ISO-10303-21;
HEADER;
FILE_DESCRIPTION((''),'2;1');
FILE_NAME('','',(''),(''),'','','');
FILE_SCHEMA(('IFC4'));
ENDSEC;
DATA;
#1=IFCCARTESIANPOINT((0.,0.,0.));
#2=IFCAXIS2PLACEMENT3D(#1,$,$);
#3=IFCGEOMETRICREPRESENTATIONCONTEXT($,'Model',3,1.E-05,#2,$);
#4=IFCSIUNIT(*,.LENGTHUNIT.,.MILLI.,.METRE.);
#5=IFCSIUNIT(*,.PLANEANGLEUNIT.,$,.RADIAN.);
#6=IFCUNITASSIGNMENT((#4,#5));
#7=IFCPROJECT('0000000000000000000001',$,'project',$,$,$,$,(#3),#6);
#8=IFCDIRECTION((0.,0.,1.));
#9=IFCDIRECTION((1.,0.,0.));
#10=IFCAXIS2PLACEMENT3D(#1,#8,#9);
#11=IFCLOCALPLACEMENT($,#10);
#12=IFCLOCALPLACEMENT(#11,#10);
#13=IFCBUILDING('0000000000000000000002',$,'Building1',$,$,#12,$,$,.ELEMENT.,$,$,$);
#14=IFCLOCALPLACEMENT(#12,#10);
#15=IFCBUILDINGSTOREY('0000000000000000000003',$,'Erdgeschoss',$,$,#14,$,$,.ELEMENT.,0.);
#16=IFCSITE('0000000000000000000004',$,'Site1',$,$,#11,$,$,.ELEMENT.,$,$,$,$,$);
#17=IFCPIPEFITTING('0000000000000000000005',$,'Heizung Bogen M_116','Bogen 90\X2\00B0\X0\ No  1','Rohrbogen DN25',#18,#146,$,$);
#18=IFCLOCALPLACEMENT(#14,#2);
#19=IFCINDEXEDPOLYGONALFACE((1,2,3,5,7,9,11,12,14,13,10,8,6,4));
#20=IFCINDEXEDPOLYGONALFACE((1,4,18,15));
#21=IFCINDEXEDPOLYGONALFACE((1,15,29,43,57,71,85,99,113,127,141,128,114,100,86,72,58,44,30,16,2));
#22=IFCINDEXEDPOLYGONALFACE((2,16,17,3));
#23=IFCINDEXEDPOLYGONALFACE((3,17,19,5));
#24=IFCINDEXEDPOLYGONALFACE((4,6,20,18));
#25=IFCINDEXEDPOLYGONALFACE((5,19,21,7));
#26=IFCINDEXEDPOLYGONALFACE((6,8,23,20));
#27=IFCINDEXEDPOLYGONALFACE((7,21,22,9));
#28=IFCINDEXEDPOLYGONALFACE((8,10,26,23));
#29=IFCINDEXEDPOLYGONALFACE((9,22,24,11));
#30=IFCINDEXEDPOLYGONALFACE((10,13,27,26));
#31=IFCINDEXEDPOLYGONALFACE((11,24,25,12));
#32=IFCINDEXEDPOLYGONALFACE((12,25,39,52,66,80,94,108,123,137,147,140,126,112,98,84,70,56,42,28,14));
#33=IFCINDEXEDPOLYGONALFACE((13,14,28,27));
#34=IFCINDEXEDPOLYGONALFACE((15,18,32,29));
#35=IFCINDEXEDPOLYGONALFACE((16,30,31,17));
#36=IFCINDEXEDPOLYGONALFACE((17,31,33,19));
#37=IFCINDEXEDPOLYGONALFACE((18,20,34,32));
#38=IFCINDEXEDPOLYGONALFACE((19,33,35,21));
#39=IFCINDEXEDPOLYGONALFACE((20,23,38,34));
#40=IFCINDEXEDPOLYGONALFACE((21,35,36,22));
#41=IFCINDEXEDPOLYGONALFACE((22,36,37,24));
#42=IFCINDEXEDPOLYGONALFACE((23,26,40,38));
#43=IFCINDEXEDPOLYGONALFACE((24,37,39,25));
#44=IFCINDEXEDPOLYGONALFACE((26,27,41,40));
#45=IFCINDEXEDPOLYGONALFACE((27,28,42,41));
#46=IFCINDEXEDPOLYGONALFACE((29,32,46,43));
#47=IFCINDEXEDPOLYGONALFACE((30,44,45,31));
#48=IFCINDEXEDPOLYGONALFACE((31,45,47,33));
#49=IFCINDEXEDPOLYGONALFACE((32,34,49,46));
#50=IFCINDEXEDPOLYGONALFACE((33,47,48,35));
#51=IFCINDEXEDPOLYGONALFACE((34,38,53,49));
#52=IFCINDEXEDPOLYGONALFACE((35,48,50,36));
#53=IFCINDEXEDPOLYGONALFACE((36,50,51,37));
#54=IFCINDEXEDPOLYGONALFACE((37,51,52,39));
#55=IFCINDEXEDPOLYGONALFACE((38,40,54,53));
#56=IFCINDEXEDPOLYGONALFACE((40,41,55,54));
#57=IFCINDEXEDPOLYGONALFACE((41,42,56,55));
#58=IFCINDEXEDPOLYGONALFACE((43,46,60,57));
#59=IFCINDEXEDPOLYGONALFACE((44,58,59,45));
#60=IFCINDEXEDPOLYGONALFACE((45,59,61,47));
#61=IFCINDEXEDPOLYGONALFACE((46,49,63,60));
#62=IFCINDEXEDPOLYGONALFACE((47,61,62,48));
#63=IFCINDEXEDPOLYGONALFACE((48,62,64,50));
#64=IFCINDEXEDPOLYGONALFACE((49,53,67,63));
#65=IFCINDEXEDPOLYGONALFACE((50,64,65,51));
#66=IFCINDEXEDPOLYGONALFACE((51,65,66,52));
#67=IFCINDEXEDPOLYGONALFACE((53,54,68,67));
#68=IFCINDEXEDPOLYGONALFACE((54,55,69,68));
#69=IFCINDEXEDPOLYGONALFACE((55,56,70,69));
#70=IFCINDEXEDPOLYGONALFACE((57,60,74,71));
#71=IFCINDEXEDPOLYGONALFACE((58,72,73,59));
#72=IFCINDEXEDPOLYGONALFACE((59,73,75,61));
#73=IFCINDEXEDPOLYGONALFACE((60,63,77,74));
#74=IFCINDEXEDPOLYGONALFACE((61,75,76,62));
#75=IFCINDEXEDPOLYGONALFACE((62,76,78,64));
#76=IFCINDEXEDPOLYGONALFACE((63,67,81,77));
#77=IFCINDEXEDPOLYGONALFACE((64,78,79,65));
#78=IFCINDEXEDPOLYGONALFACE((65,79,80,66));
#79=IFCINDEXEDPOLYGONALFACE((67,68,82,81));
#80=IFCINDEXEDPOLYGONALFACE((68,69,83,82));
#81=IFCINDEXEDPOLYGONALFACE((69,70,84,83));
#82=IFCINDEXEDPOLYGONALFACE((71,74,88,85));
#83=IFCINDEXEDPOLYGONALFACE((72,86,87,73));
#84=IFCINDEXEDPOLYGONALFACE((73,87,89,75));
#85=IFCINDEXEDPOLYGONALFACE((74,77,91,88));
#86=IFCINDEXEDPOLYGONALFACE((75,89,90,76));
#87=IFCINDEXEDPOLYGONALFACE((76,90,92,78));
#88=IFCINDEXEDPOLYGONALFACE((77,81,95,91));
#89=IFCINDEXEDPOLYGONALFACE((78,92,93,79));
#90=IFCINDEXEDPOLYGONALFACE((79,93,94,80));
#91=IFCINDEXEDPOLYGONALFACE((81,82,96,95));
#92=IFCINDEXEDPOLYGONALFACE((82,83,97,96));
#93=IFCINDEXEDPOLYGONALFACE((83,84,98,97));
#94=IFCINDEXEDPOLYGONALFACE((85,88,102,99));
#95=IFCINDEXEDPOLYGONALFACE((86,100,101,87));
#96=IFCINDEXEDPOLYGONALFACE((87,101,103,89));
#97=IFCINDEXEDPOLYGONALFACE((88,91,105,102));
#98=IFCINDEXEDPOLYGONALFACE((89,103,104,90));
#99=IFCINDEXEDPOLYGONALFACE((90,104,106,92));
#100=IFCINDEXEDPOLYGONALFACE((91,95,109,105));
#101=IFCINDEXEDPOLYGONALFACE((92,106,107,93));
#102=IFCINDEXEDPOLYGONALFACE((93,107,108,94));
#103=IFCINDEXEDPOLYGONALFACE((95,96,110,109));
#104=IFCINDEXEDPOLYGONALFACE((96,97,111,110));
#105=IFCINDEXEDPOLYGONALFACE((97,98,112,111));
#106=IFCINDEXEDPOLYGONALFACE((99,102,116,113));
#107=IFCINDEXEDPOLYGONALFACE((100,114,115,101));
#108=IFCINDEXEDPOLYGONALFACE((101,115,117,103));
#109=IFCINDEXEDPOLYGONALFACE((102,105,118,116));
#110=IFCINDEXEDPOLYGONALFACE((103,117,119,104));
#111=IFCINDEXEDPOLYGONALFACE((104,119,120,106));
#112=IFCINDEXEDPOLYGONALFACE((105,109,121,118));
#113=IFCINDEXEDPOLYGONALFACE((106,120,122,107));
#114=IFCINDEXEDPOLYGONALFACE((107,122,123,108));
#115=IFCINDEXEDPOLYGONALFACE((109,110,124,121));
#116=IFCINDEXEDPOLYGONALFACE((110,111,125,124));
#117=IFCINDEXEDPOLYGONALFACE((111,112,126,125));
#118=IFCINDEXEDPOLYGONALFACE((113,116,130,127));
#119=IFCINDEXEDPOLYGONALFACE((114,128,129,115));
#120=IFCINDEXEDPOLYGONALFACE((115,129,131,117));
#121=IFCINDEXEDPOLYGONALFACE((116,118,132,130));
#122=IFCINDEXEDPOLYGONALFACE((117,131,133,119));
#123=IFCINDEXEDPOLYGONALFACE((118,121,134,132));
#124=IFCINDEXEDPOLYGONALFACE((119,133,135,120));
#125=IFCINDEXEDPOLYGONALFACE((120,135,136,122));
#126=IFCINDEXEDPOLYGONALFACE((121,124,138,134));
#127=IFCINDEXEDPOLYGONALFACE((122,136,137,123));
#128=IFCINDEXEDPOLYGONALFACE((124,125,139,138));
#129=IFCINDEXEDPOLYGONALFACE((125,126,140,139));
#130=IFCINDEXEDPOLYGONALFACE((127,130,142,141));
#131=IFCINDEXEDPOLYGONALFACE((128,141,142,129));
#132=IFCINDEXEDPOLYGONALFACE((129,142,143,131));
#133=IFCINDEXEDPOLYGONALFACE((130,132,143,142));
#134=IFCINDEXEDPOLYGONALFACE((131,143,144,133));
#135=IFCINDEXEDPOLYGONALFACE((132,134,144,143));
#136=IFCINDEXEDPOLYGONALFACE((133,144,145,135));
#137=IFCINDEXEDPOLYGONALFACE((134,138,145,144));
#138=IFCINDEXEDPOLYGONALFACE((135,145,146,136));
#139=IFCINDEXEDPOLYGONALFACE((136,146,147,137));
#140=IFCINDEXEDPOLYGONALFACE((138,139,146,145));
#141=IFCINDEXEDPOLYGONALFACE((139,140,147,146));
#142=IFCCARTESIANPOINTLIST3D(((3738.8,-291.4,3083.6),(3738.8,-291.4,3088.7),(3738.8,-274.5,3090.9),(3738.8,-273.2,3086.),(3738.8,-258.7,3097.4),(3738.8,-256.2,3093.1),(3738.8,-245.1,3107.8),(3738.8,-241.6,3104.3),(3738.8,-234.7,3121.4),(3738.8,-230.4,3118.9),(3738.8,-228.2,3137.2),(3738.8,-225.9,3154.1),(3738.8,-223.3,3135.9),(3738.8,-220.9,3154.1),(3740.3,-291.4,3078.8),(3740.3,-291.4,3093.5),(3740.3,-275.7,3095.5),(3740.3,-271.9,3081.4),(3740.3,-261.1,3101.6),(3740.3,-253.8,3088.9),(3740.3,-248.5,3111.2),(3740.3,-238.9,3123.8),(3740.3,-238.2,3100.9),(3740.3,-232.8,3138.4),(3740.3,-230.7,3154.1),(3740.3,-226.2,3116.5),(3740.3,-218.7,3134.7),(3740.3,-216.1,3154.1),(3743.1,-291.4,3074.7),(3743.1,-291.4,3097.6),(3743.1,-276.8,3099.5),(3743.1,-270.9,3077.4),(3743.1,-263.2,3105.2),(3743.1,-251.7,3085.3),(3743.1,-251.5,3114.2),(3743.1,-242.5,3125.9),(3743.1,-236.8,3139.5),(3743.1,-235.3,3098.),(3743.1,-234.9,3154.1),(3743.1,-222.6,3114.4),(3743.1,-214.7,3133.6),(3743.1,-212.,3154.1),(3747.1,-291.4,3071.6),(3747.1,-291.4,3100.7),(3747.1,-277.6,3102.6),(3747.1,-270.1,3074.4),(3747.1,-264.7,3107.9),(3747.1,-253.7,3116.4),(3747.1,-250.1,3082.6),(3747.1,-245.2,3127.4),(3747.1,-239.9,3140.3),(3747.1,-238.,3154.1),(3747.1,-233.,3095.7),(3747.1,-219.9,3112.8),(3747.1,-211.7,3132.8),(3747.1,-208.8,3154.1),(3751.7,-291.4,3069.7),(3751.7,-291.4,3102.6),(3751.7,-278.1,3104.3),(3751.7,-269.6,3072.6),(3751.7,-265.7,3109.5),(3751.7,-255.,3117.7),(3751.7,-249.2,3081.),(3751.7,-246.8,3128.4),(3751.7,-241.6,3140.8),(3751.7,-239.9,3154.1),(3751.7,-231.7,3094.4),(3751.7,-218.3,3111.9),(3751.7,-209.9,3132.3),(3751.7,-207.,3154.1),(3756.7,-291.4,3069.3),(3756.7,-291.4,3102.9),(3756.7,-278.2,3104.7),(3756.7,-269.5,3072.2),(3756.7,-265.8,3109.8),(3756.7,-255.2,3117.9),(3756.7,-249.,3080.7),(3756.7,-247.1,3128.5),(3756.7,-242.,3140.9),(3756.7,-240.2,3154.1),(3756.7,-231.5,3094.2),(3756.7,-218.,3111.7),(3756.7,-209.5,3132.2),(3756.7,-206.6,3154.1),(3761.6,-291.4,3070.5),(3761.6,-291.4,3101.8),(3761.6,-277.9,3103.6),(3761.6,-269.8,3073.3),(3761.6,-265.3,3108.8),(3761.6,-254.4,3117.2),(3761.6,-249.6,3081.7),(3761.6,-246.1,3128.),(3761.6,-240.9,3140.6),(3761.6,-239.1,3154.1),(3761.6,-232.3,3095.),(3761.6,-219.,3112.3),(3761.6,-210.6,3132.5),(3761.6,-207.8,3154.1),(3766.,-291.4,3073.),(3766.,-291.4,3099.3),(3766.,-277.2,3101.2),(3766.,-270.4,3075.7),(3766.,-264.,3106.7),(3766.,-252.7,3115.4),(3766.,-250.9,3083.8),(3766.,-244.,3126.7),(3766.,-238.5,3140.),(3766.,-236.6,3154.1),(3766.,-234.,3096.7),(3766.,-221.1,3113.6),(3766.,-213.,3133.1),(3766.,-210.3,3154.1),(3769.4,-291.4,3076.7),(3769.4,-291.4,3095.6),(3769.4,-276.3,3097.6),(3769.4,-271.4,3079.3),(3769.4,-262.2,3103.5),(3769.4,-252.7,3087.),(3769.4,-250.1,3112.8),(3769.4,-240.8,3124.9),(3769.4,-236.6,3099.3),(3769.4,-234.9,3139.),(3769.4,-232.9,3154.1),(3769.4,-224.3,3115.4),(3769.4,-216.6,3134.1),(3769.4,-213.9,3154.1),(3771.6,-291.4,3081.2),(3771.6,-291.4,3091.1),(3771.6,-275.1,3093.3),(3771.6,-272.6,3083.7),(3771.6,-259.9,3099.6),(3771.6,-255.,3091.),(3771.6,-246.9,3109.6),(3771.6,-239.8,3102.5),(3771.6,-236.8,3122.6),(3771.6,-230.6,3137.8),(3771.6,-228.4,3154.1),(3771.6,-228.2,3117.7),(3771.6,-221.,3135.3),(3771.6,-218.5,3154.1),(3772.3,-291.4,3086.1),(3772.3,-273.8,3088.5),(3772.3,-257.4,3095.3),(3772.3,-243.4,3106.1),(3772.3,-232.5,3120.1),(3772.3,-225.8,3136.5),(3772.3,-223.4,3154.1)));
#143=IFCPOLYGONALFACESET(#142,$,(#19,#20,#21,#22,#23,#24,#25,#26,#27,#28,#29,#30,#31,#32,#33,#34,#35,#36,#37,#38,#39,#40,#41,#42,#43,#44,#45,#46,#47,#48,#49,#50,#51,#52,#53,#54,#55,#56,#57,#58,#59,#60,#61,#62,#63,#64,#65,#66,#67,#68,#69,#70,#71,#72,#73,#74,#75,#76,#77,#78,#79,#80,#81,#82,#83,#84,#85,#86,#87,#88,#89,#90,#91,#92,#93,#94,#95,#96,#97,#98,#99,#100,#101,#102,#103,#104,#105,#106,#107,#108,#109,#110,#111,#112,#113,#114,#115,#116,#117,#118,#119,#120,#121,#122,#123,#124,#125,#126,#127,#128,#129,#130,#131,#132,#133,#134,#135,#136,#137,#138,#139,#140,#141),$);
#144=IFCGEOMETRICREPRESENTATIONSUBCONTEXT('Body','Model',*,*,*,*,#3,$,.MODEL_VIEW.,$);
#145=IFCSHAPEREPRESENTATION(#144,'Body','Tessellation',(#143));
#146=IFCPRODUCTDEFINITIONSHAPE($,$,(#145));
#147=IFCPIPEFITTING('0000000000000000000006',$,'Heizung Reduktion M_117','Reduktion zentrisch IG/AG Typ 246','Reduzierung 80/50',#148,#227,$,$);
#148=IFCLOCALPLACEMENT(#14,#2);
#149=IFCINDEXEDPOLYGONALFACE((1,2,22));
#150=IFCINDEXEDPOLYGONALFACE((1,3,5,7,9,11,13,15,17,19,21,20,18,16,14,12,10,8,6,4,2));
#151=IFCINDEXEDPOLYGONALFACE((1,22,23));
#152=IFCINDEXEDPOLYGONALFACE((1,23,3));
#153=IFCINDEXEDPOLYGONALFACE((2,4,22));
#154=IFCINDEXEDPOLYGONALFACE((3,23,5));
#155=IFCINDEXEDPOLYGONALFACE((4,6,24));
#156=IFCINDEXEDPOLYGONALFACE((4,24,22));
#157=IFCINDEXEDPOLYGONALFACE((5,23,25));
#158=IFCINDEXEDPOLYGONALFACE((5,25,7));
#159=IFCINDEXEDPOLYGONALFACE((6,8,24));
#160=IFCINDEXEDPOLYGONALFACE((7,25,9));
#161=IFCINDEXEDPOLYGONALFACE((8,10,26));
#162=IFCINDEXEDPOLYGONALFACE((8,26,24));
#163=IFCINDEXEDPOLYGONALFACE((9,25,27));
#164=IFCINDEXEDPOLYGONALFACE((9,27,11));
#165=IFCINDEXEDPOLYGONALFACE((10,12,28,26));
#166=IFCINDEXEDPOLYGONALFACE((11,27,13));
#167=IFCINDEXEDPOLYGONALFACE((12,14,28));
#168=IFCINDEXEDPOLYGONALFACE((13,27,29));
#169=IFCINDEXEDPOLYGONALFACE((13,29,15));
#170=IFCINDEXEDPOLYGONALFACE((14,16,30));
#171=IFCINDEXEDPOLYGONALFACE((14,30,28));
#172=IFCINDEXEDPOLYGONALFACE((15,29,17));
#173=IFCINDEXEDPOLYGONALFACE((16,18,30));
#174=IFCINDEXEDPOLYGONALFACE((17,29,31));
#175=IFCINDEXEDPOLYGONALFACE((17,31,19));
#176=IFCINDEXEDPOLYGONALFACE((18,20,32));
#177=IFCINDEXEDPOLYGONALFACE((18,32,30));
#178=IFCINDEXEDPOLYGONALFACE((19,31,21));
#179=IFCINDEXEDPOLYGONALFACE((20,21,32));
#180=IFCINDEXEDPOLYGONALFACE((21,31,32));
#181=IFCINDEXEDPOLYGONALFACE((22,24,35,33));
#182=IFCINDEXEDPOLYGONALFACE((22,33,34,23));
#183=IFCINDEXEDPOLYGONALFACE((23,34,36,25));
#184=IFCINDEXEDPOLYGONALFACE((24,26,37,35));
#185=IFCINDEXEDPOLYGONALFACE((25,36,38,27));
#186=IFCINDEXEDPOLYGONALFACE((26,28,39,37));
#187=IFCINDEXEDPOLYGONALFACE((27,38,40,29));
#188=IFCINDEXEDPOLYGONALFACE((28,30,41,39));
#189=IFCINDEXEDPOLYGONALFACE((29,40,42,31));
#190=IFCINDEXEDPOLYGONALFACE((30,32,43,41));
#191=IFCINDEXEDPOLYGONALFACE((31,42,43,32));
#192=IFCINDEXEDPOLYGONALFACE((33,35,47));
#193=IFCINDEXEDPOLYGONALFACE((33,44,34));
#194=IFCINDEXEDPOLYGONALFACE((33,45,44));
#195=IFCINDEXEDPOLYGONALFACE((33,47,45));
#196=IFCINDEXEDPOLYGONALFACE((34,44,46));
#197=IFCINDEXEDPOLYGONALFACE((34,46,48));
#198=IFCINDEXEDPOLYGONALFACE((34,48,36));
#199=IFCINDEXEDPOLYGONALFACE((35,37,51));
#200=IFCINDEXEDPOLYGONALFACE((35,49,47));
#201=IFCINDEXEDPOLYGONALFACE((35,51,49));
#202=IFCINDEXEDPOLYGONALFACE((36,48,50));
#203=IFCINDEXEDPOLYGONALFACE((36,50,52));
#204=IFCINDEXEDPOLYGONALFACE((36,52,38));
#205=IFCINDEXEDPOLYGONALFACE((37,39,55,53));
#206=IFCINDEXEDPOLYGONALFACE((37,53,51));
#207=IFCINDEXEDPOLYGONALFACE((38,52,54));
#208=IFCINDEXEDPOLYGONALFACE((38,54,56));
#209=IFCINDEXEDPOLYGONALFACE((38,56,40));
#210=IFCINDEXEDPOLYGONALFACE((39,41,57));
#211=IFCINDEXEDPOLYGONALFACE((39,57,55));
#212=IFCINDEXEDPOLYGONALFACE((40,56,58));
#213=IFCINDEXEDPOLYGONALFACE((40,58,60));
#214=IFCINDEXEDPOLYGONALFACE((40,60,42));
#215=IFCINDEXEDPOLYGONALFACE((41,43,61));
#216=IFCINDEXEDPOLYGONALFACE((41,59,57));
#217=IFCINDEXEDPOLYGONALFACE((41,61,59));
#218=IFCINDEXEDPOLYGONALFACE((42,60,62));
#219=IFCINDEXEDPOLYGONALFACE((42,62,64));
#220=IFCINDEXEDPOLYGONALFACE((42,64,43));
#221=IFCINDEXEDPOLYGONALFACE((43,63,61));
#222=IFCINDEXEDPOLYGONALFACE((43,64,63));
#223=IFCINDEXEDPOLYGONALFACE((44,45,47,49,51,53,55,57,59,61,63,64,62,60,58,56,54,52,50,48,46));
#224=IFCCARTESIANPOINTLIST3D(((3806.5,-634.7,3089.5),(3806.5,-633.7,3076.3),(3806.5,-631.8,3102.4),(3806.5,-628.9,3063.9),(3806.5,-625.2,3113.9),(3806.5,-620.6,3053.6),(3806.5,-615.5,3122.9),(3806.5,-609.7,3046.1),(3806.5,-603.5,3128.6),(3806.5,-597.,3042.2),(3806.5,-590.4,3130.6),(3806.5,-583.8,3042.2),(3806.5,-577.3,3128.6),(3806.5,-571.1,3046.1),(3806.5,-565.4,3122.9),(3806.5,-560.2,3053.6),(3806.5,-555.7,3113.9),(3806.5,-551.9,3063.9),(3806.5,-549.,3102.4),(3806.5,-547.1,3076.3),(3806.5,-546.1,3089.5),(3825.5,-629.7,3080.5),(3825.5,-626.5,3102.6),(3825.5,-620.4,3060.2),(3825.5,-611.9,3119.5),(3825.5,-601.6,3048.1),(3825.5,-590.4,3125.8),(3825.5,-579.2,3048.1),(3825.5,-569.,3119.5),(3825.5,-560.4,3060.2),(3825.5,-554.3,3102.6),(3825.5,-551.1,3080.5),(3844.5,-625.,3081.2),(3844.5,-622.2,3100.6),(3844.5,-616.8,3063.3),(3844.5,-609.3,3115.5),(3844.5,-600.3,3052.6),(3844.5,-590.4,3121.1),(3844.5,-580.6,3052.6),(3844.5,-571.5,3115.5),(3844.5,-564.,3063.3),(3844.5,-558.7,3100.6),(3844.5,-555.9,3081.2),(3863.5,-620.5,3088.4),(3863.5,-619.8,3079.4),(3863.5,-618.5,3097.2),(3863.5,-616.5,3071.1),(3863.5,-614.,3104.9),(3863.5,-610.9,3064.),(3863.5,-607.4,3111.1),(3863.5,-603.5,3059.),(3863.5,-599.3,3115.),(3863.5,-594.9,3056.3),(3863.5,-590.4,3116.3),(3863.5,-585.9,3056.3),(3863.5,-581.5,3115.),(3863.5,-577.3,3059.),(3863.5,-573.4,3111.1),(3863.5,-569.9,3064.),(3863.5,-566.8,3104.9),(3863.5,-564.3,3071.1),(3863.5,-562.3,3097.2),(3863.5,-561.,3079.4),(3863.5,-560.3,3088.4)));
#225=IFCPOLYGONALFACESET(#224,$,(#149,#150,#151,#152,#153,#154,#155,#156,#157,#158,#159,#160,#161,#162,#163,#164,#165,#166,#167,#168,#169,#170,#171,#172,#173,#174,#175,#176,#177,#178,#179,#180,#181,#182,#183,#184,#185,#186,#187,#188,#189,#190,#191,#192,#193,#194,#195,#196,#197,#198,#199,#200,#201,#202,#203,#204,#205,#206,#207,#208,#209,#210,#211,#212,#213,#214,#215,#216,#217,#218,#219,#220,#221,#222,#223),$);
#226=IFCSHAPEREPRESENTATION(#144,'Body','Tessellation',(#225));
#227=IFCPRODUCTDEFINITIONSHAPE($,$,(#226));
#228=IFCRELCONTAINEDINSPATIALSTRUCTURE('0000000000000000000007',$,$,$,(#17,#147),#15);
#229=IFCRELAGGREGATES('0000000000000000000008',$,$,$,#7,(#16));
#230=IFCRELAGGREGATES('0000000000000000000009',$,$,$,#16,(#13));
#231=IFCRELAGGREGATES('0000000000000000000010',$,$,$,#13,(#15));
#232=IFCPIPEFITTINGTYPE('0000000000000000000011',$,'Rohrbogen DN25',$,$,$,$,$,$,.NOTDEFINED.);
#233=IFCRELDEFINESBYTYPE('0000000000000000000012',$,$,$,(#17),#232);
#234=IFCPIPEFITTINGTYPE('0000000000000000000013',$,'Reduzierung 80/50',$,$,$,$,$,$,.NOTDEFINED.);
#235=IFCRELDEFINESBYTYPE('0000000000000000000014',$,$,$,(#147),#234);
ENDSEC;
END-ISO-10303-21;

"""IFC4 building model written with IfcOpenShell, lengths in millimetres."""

from ifc_helpers import new_model, entity, si_unit, frame, origin, origin_with_axes, place, context, subcontext, project, spatial, source, transform, mapped, type_object, element, save


model = new_model("IFC4")

# Units and contexts
model_context = context("Model", 3, precision=1e-05, world=origin())
body_context = subcontext(model_context, "Body", "Model", "MODEL_VIEW")
ifc_project = project(units=[si_unit("LENGTHUNIT", "METRE", prefix="MILLI"), si_unit("PLANEANGLEUNIT", "RADIAN")], contexts=[model_context])

# Site, building, storey
site_placement = place(None, origin_with_axes())
site = spatial("IfcSite", under=ifc_project, at=site_placement, Name="Site1", CompositionType="ELEMENT")
building_placement = place(site_placement, origin_with_axes())
building = spatial("IfcBuilding", under=site, at=building_placement, Name="Building1", CompositionType="ELEMENT")
storey_placement = place(building_placement, origin_with_axes())
storey = spatial("IfcBuildingStorey", under=building, at=storey_placement, Name="Erdgeschoss", CompositionType="ELEMENT", Elevation=0.0)

# Shared definitions
pipe_fitting_type_1 = type_object("IfcPipeFittingType", Name="Rohrbogen DN25", PredefinedType="NOTDEFINED")

# Pipe fittings
shared_shape_1 = source(origin_with_axes(), body_context, "Body", "SolidModel", [
    entity("IfcRevolvedAreaSolid", entity("IfcCircleProfileDef", "AREA", None, entity("IfcAxis2Placement2D", entity("IfcCartesianPoint", [0.0, 0.0]), entity("IfcDirection", [1.0, 0.0])), 16.9), entity("IfcAxis2Placement3D", entity("IfcCartesianPoint", [42.4, 25.6, 0.0]), entity("IfcDirection", [-1.0, 0.0, 0.0]), entity("IfcDirection", [0.0, 0.0, -1.0])), entity("IfcAxis1Placement", entity("IfcCartesianPoint", [0.0, 68.0, 0.0]), entity("IfcDirection", [-1.0, 0.0, 0.0])), 1.570796),
])
pipe_fitting_1_placement = place(storey_placement, frame((3755.5, -249.0, 3111.7), z_axis=(0.0, 0.0, 1.0), x_axis=(1.0, 0.0, 0.0)))
element("IfcPipeFitting", 1, at=pipe_fitting_1_placement, inside=storey, type_object=pipe_fitting_type_1, Name="Heizung Bogen M_116", Description="Bogen 90° No  1", ObjectType="Rohrbogen DN25", context=body_context, shape_type="MappedRepresentation", body=[
    mapped(shared_shape_1, transform((0.0, 0.0, 0.0), x_axis=(0.0, 0.0, 1.0), y_axis=(0.0, 1.0, 0.0), z_axis=(-1.0, 0.0, 0.0), scale=1.0)),
])
pipe_fitting_type_2 = type_object("IfcPipeFittingType", Name="Reduzierung 80/50", PredefinedType="NOTDEFINED")
axis2_placement2_d_1 = entity("IfcAxis2Placement2D", entity("IfcCartesianPoint", [0.0, 0.0]), entity("IfcDirection", [1.0, 0.0]))
shared_shape_2 = source(origin_with_axes(), body_context, "Body", "SolidModel", [
    entity("IfcExtrudedAreaSolidTapered", entity("IfcCircleProfileDef", "AREA", None, axis2_placement2_d_1, 44.5), entity("IfcAxis2Placement3D", entity("IfcCartesianPoint", [-28.5, -0.1, 0.0]), entity("IfcDirection", [1.0, 0.0, 0.0]), entity("IfcDirection", [0.0, 0.0, 1.0])), entity("IfcDirection", [0.0, 0.0, 1.0]), 57.0, entity("IfcCircleProfileDef", "AREA", None, axis2_placement2_d_1, 30.1)),
])
pipe_fitting_2_placement = place(storey_placement, frame((3835.0, -590.3, 3086.1), z_axis=(0.0, 0.0, 1.0), x_axis=(1.0, 0.0, 0.0)))
element("IfcPipeFitting", 2, at=pipe_fitting_2_placement, inside=storey, type_object=pipe_fitting_type_2, Name="Heizung Reduktion M_117", Description="Reduktion zentrisch IG/AG Typ 246", ObjectType="Reduzierung 80/50", context=body_context, shape_type="MappedRepresentation", body=[
    mapped(shared_shape_2, transform((0.0, 0.0, 0.0), x_axis=(1.0, 0.0, 0.0), y_axis=(0.0, 1.0, 0.0), z_axis=(0.0, 0.0, 1.0), scale=1.0)),
])

save(model, "model.ifc")
